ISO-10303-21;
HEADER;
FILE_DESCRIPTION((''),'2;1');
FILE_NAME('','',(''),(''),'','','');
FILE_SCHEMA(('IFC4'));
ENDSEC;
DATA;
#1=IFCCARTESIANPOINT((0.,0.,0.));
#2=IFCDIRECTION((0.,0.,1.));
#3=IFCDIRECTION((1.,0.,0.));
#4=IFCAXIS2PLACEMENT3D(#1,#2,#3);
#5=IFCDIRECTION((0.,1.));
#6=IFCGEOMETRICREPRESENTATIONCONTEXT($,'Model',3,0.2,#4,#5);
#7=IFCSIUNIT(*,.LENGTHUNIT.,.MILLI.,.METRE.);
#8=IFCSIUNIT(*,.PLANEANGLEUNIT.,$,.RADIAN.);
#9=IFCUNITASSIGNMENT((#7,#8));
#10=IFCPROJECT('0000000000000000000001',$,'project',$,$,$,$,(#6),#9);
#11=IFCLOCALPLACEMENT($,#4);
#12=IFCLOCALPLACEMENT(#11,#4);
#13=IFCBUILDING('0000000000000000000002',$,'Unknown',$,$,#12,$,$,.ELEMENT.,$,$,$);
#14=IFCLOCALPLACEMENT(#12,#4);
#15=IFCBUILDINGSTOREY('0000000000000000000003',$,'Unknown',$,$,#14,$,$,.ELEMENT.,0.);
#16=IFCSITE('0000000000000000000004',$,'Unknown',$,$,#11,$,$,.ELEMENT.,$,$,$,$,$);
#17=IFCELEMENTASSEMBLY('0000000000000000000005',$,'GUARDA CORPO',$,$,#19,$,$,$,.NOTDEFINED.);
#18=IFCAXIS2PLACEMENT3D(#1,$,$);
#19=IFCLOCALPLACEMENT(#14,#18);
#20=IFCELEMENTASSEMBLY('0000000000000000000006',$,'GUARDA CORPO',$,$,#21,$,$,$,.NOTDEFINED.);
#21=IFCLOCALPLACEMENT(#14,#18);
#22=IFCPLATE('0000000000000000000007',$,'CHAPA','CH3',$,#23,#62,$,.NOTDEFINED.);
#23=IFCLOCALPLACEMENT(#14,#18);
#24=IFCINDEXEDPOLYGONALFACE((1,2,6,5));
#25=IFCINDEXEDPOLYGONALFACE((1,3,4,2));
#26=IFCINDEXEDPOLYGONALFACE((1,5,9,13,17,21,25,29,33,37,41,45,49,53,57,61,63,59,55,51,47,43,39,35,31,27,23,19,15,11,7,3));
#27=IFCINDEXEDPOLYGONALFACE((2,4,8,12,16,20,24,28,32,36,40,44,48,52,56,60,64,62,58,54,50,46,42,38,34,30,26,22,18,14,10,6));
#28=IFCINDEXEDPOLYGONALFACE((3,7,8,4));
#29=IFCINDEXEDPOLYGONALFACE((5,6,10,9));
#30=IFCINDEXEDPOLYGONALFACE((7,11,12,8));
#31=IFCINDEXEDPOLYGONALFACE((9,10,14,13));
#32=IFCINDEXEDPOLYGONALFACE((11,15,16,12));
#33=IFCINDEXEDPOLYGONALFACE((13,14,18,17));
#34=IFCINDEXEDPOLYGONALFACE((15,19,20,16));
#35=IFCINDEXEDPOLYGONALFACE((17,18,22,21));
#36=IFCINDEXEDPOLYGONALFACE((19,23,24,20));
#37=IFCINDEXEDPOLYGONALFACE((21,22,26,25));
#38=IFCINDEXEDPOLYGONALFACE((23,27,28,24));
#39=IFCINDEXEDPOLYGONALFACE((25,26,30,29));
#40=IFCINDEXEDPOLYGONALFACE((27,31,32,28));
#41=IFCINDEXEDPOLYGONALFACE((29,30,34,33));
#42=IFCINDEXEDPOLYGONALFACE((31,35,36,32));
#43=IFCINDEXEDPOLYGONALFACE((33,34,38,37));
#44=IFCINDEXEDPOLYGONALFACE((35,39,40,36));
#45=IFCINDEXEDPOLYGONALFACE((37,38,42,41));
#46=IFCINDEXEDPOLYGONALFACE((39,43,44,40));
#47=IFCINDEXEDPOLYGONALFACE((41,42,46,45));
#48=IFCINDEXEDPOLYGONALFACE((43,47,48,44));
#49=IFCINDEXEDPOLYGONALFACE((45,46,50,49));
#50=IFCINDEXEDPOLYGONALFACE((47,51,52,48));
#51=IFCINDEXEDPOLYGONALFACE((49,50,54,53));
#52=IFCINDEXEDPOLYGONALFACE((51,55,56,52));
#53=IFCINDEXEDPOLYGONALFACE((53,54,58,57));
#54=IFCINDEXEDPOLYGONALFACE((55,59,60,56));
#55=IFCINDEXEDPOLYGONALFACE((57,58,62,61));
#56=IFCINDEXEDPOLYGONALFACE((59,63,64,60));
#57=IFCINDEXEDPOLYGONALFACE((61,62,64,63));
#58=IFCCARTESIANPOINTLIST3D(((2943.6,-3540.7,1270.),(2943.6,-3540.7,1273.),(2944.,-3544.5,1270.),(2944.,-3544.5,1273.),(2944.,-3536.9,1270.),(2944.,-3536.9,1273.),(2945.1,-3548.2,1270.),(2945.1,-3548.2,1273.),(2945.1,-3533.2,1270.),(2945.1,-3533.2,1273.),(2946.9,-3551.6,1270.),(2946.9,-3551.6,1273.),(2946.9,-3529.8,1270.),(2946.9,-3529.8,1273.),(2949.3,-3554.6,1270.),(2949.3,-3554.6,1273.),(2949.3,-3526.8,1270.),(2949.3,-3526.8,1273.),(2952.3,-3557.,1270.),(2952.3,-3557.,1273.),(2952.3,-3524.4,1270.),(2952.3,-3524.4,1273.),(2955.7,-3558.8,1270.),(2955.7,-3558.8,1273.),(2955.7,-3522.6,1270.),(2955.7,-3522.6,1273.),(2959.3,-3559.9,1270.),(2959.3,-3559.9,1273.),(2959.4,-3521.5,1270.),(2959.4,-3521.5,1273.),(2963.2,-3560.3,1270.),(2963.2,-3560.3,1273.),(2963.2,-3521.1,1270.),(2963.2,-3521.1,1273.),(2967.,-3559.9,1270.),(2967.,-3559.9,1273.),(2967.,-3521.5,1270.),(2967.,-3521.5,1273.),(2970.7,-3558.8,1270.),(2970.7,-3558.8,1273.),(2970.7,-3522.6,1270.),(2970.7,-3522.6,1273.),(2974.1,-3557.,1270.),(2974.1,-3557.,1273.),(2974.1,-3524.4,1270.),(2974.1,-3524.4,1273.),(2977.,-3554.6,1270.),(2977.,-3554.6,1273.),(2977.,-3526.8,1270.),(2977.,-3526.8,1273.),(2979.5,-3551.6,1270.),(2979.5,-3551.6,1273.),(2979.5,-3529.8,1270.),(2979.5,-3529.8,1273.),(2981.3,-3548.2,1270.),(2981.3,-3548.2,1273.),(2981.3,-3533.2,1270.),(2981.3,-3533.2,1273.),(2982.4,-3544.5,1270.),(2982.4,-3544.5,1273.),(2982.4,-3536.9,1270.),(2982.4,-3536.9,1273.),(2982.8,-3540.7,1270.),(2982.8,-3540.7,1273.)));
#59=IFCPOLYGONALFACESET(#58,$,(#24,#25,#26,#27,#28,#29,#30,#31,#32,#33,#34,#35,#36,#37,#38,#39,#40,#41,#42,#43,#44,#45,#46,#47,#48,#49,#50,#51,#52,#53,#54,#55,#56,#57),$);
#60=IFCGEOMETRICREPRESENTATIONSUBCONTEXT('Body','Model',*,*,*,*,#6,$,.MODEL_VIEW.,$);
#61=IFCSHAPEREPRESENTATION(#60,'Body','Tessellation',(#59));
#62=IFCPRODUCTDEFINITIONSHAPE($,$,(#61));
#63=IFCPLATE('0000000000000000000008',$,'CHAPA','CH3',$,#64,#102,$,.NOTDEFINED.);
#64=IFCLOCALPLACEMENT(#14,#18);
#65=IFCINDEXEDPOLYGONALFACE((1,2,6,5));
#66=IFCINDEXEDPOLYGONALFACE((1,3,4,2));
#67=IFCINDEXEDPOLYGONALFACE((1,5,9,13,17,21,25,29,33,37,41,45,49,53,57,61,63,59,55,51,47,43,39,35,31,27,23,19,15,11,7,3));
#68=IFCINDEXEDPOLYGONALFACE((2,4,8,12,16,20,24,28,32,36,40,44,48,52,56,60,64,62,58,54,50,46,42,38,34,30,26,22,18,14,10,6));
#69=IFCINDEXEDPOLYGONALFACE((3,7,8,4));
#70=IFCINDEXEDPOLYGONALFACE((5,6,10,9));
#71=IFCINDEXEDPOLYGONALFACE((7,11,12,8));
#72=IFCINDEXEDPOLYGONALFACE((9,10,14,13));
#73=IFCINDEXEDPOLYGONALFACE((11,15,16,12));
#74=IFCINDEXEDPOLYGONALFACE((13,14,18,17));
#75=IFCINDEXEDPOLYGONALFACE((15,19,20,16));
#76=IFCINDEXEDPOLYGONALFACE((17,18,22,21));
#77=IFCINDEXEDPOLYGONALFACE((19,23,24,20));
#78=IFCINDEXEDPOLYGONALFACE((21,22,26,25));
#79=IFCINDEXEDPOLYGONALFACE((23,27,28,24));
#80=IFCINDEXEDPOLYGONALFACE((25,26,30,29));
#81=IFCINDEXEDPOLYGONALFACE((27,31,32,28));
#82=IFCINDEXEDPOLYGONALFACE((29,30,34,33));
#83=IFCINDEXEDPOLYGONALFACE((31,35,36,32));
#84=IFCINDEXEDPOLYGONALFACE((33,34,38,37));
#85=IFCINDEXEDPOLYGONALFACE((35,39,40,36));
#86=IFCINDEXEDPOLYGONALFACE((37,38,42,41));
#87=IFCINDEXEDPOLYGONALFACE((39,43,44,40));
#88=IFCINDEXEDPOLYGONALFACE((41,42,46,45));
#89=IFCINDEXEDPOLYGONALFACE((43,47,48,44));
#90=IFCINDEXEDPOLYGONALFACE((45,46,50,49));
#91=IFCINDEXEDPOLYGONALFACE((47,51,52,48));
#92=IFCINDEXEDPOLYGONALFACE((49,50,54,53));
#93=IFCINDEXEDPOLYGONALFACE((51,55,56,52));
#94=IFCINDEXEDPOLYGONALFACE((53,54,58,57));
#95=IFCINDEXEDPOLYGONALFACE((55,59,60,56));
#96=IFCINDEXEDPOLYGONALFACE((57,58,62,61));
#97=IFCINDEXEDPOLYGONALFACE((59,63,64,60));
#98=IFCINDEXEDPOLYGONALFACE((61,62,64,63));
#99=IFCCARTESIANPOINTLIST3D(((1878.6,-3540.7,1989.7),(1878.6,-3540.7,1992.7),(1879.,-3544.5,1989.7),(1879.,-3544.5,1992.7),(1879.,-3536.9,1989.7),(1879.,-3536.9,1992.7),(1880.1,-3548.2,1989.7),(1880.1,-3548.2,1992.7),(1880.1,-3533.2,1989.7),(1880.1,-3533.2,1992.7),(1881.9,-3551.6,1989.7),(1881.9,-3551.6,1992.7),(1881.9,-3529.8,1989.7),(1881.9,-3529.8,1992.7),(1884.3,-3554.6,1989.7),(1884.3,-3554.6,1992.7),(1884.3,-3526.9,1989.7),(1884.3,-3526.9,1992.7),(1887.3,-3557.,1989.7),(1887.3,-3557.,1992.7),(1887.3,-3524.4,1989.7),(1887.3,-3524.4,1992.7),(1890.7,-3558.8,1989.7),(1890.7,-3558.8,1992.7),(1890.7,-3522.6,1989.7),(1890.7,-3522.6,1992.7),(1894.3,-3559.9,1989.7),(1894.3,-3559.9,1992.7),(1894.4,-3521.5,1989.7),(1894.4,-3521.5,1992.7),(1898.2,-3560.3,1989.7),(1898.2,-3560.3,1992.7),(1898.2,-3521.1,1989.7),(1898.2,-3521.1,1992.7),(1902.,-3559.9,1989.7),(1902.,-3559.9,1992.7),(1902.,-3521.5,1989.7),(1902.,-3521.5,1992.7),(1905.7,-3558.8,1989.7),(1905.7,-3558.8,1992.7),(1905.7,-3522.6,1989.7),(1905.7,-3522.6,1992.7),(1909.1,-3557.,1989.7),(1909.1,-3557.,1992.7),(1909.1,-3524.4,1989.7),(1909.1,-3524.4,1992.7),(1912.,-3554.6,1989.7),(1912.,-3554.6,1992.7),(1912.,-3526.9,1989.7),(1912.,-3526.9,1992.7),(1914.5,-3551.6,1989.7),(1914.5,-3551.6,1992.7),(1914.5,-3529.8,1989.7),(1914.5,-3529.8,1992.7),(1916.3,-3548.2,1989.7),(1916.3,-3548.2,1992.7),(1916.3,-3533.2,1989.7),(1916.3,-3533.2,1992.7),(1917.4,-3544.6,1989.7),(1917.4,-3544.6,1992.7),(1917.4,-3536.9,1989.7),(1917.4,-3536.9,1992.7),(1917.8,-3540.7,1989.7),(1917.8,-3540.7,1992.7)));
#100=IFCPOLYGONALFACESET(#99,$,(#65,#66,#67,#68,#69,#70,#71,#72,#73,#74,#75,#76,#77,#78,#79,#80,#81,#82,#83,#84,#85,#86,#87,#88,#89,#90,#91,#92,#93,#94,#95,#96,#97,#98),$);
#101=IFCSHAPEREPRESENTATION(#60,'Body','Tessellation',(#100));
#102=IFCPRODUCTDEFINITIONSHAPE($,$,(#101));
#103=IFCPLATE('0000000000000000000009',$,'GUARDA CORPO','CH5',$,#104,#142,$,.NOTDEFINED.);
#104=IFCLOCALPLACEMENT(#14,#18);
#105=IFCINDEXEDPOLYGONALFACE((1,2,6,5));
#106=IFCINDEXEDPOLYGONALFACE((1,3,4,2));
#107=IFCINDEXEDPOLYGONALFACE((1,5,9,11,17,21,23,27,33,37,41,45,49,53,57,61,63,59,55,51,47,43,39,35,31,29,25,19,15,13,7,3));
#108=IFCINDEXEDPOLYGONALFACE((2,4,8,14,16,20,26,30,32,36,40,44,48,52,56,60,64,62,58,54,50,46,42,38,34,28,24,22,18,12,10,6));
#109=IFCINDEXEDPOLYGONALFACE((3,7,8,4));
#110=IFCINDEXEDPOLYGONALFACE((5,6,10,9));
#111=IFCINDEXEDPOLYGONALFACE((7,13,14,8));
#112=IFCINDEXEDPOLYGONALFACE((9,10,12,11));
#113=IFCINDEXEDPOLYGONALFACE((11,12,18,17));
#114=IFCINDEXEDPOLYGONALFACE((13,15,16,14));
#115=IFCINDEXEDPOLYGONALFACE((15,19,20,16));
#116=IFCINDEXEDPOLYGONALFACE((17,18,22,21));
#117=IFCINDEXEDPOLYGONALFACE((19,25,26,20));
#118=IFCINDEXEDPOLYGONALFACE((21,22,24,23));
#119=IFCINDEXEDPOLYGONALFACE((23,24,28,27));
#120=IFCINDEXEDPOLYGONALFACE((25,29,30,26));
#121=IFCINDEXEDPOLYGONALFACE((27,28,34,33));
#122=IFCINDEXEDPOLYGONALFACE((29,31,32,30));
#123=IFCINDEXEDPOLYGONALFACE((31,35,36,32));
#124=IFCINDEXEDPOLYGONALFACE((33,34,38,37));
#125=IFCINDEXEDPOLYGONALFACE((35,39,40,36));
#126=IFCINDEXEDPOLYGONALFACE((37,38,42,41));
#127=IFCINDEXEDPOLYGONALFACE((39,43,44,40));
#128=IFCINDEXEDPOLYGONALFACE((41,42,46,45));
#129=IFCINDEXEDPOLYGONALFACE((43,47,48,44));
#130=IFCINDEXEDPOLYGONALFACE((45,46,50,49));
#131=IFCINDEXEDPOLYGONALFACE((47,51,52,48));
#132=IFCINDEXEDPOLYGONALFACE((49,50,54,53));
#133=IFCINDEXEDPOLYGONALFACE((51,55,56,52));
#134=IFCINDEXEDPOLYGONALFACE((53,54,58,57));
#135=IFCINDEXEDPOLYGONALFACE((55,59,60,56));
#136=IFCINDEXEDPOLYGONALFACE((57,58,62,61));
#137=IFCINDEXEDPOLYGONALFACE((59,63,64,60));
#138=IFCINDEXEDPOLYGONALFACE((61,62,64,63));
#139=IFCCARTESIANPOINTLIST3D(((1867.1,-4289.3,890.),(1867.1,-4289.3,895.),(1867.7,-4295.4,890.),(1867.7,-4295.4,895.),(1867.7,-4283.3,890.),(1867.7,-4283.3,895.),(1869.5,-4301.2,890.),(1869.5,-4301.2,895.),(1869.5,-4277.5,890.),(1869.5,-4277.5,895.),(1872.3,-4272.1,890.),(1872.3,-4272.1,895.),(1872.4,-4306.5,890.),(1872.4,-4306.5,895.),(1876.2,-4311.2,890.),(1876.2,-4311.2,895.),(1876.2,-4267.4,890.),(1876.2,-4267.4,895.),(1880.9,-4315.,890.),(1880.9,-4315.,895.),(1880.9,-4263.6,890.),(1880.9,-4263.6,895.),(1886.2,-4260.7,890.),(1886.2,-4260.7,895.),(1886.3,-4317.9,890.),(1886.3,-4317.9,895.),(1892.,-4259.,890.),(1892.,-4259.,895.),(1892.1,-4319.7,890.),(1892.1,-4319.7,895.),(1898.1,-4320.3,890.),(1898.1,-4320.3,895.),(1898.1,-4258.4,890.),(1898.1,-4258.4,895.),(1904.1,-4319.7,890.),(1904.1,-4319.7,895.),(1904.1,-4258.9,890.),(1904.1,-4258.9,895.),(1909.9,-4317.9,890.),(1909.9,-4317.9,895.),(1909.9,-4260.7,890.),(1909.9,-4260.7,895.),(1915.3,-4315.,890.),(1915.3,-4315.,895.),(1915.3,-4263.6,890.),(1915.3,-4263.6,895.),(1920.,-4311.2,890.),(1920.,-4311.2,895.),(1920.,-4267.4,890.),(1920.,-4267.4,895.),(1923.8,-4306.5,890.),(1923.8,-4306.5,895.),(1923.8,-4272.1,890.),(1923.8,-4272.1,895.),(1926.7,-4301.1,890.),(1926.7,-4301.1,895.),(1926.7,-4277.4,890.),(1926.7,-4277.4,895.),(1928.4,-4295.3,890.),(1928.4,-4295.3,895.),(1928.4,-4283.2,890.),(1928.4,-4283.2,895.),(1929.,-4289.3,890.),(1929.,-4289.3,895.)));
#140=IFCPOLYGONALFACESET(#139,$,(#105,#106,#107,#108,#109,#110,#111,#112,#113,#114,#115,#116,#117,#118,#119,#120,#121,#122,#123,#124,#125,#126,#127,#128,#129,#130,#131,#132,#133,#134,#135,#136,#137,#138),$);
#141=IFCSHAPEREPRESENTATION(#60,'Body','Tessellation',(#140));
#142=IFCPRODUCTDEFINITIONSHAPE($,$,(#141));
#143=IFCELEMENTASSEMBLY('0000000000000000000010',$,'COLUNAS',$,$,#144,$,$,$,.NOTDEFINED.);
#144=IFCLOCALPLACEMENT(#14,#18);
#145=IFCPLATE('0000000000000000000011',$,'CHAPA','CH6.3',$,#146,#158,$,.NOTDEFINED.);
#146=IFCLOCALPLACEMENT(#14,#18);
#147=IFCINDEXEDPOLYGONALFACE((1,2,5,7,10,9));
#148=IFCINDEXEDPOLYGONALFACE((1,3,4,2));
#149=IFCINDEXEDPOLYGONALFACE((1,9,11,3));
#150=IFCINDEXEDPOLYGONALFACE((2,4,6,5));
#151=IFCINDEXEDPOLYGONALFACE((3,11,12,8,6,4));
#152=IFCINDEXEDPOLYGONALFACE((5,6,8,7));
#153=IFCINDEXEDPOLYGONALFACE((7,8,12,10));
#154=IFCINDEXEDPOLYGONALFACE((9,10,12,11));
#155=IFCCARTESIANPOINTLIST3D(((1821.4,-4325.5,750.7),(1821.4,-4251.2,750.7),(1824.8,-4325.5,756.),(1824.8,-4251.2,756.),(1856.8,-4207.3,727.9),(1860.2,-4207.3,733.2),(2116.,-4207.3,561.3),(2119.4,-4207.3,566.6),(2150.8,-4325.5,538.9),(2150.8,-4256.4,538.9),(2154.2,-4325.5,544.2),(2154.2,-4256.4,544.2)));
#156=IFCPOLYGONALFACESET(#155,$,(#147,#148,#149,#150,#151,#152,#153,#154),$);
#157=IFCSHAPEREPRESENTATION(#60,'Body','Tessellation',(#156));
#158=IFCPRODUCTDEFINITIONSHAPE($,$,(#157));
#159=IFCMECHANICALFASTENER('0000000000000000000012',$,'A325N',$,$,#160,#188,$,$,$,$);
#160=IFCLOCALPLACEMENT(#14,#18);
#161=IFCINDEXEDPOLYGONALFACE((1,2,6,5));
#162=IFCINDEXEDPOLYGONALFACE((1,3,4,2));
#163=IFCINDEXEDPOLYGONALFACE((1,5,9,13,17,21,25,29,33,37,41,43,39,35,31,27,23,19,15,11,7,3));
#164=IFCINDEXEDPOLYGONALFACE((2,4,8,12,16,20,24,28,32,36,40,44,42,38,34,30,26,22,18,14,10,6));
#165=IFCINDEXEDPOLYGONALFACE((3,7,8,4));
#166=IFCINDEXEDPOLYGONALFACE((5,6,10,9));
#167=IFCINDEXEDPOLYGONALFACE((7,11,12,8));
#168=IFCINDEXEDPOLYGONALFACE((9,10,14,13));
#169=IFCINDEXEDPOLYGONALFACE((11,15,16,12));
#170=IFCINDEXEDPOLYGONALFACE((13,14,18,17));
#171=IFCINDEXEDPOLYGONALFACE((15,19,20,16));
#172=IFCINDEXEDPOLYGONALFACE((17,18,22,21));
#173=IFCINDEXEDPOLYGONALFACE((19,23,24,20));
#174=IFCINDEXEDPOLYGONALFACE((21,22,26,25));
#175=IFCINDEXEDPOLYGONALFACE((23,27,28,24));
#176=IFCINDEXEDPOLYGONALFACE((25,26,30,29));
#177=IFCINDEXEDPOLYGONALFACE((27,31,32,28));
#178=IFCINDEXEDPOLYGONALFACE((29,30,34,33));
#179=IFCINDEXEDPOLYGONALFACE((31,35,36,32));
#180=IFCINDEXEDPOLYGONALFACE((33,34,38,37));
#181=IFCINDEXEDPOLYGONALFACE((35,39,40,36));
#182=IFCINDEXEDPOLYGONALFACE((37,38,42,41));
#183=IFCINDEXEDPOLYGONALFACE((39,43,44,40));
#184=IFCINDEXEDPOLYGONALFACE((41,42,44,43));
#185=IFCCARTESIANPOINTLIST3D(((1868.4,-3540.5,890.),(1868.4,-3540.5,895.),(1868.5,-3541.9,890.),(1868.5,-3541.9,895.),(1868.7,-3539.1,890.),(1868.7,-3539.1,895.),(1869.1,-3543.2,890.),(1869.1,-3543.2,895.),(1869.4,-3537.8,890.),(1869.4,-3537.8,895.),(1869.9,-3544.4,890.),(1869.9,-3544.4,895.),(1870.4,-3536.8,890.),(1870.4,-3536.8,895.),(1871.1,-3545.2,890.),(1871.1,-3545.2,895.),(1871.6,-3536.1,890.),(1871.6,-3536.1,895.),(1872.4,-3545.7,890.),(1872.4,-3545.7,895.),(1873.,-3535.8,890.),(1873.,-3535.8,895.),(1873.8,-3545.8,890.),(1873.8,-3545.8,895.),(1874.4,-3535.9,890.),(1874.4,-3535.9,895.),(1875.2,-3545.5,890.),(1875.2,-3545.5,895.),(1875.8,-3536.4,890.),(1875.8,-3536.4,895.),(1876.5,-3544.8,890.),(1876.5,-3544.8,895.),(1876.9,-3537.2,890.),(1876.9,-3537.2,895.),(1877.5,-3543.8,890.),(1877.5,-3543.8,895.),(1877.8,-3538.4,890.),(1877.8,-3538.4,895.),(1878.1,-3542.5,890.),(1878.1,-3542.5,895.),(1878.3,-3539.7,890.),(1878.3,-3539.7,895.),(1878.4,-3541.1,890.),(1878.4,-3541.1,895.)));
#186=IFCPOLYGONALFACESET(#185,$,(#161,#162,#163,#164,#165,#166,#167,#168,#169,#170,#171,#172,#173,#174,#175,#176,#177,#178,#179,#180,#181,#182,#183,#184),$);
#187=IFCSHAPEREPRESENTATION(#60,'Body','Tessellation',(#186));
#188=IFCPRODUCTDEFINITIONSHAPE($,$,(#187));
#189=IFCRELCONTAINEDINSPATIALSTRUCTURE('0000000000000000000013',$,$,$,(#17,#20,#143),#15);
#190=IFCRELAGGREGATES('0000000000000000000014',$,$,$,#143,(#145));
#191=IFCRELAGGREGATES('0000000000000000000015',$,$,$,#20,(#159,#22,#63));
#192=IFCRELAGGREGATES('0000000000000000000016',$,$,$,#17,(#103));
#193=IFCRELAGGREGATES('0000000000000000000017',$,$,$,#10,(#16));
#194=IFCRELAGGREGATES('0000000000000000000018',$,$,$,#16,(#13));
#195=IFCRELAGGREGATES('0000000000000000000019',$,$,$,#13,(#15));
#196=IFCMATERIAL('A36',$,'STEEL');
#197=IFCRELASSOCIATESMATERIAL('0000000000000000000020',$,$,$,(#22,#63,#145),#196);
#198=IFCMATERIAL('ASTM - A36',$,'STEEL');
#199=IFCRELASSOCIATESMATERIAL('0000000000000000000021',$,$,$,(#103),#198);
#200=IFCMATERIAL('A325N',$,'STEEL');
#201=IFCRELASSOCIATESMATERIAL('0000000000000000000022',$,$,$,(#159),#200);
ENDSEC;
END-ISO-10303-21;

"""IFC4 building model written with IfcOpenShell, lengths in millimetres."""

from ifc_helpers import new_model, si_unit, direction, frame, origin_with_axes, place, context, subcontext, project, spatial, line, arc, indexed_curve, outline, extrude, source, transform, mapped, material, element, aggregate, save


model = new_model("IFC4")

# Units and contexts
model_context = context("Model", 3, precision=0.2, world=origin_with_axes(), true_north=direction((0.0, 1.0)))
body_context = subcontext(model_context, "Body", "Model", "MODEL_VIEW")
ifc_project = project(units=[si_unit("LENGTHUNIT", "METRE", prefix="MILLI"), si_unit("PLANEANGLEUNIT", "RADIAN")], contexts=[model_context])

# Site, building, storey
site_placement = place(None, origin_with_axes())
site = spatial("IfcSite", under=ifc_project, at=site_placement, Name="Unknown", CompositionType="ELEMENT")
building_placement = place(site_placement, origin_with_axes())
building = spatial("IfcBuilding", under=site, at=building_placement, Name="Unknown", CompositionType="ELEMENT")
storey_placement = place(building_placement, origin_with_axes())
storey = spatial("IfcBuildingStorey", under=building, at=storey_placement, Name="Unknown", CompositionType="ELEMENT", Elevation=0.0)

# Element assembly
assembly_1_placement = place(storey_placement, frame((833.2, -4289.3, 1615.0), z_axis=(-0.000512, 1.0, -0.000003), x_axis=(0.000003, 0.000003, 1.0)))
assembly_1 = element("IfcElementAssembly", 1, at=assembly_1_placement, inside=storey, Name="GUARDA CORPO", PredefinedType="NOTDEFINED")

# Shared definitions
ifc_material_1 = material(Name="A36", Category="STEEL")

# Element assembly
assembly_2_placement = place(storey_placement, frame((833.2, -3540.7, 1615.0), z_axis=(-0.000512, -1.0, -0.000003), x_axis=(0.000003, -0.000003, 1.0)))
assembly_2 = element("IfcElementAssembly", 2, at=assembly_2_placement, inside=storey, Name="GUARDA CORPO", PredefinedType="NOTDEFINED")

# Plates
ifc_material_2 = material(Name="ASTM - A36", Category="STEEL")
plate_1_placement = place(assembly_2_placement, frame((-343.5, -2110.8, 2.7), z_axis=(1.0, 0.0, 0.0), x_axis=(0.0, -0.290285, 0.95694)))
plate_1 = element("IfcPlate", 3, at=plate_1_placement, material=ifc_material_1, Name="CHAPA", Description="CH3", PredefinedType="NOTDEFINED", context=body_context, shape_type="SolidModel", body=[
    extrude(outline(indexed_curve([(0.0, 0.0), (3.8, 0.0), (7.6, 0.7), (11.2, 2.2), (14.4, 4.4), (17.1, 7.1), (19.2, 10.3), (20.7, 13.8), (21.4, 17.6), (21.4, 21.4), (20.7, 25.2), (19.2, 28.7), (17.1, 31.9), (14.4, 34.7), (11.2, 36.8), (7.6, 38.3), (3.8, 39.0), (0.0, 39.0), (-3.8, 38.3), (-7.3, 36.8), (-10.5, 34.7), (-13.2, 31.9), (-15.4, 28.7), (-16.8, 25.2), (-17.6, 21.4), (-17.6, 17.6), (-16.8, 13.8), (-15.4, 10.3), (-13.2, 7.1), (-10.5, 4.4), (-7.3, 2.2), (-3.8, 0.7)], segments=[line(1, 2, 3, 4, 5, 6, 7, 8, 9, 10, 11, 12, 13, 14, 15, 16, 17, 18, 19, 20, 21, 22, 23, 24, 25, 26, 27, 28, 29, 30, 31, 32, 1)])), frame((0.0, 0.0, 1.5), z_axis=(0.0, 0.0, 1.0), x_axis=(1.0, 0.0, 0.0)), (0.0, 0.0, -1.0), 3.0),
])
plate_2_placement = place(assembly_2_placement, frame((376.2, -1045.8, 3.3), z_axis=(1.0, 0.0, 0.0), x_axis=(0.0, -0.290285, 0.95694)))
plate_2 = element("IfcPlate", 4, at=plate_2_placement, material=ifc_material_1, Name="CHAPA", Description="CH3", PredefinedType="NOTDEFINED", context=body_context, shape_type="SolidModel", body=[
    extrude(outline(indexed_curve([(0.0, 0.0), (3.8, 0.0), (7.6, 0.7), (11.2, 2.2), (14.4, 4.4), (17.1, 7.1), (19.2, 10.3), (20.7, 13.8), (21.4, 17.6), (21.4, 21.4), (20.7, 25.2), (19.2, 28.7), (17.1, 31.9), (14.4, 34.7), (11.2, 36.8), (7.6, 38.3), (3.8, 39.0), (0.0, 39.0), (-3.8, 38.3), (-7.3, 36.8), (-10.5, 34.7), (-13.2, 31.9), (-15.4, 28.7), (-16.8, 25.2), (-17.6, 21.4), (-17.6, 17.6), (-16.8, 13.8), (-15.4, 10.3), (-13.2, 7.1), (-10.5, 4.4), (-7.3, 2.2), (-3.8, 0.7)], segments=[line(1, 2, 3, 4, 5, 6, 7, 8, 9, 10, 11, 12, 13, 14, 15, 16, 17, 18, 19, 20, 21, 22, 23, 24, 25, 26, 27, 28, 29, 30, 31, 32, 1)])), frame((0.0, 0.0, 1.5), z_axis=(0.0, 0.0, 1.0), x_axis=(1.0, 0.0, 0.0)), (0.0, 0.0, -1.0), 3.0),
])
plate_3_placement = place(assembly_1_placement, frame((-722.5, 1095.3, 5.5), z_axis=(1.0, 0.0, 0.0), x_axis=(0.0, -0.290285, 0.95694)))
plate_3 = element("IfcPlate", 5, at=plate_3_placement, material=ifc_material_2, Name="GUARDA CORPO", Description="CH5", PredefinedType="NOTDEFINED", context=body_context, shape_type="SolidModel", body=[
    extrude(outline(indexed_curve([(0.0, 0.0), (6.1, 0.0), (12.0, 1.2), (17.6, 3.5), (22.7, 6.9), (27.0, 11.2), (30.3, 16.2), (32.7, 21.8), (33.8, 27.8), (33.8, 33.8), (32.7, 39.8), (30.3, 45.4), (27.0, 50.4), (22.7, 54.7), (17.6, 58.1), (12.0, 60.4), (6.1, 61.6), (0.0, 61.6), (-6.0, 60.4), (-11.6, 58.1), (-16.6, 54.7), (-20.9, 50.4), (-24.3, 45.4), (-26.6, 39.8), (-27.8, 33.8), (-27.8, 27.8), (-26.6, 21.8), (-24.3, 16.2), (-20.9, 11.2), (-16.6, 6.9), (-11.6, 3.5), (-6.0, 1.2)], segments=[line(1, 2, 3, 4, 5, 6, 7, 8, 9, 10, 11, 12, 13, 14, 15, 16, 17, 18, 19, 20, 21, 22, 23, 24, 25, 26, 27, 28, 29, 30, 31, 32, 1)])), frame((0.0, 0.0, 2.5), z_axis=(0.0, 0.0, 1.0), x_axis=(1.0, 0.0, 0.0)), (0.0, 0.0, -1.0), 5.0),
])

# Element assembly, plate
assembly_3_placement = place(storey_placement, frame((2988.4, -4354.0, 7.9), z_axis=(0.0, -1.0, 0.0), x_axis=(0.0, 0.0, 1.0)))
assembly_3 = element("IfcElementAssembly", 6, at=assembly_3_placement, inside=storey, Name="COLUNAS", PredefinedType="NOTDEFINED")
plate_4_placement = place(assembly_3_placement, frame((745.4, 1165.4, -28.5), z_axis=(0.841179, -0.540757, 0.0), x_axis=(-0.540757, -0.841179, 0.0)))
plate_4 = element("IfcPlate", 7, at=plate_4_placement, material=ifc_material_1, Name="CHAPA", Description="CH6.3", PredefinedType="NOTDEFINED", context=body_context, shape_type="SolidModel", body=[
    extrude(outline(indexed_curve([(0.0, 0.0), (391.6, 0.0), (391.6, 69.1), (350.2, 118.2), (42.1, 118.2), (0.0, 74.3)], segments=[line(1, 2, 3, 4, 5, 6, 1)])), frame((0.0, 0.0, 3.1), z_axis=(0.0, 0.0, 1.0), x_axis=(1.0, 0.0, 0.0)), (0.0, 0.0, -1.0), 6.3),
])
aggregate(assembly_3, [plate_4])

# Shared definitions
ifc_material_3 = material(Name="A325N", Category="STEEL")

# Mechanical fastener
shared_shape_1 = source(origin_with_axes(), body_context, "Body", "SweptSolid", [
    extrude(outline(indexed_curve([(5.0, 0.0), (0.0, 5.0), (-5.0, 0.0), (0.0, -5.0)], segments=[arc(1, 2, 3), arc(3, 4, 1)])), frame((0.0, 0.0, 0.0), z_axis=(0.0, 0.0, -1.0), x_axis=(0.0, 1.0, 0.0)), (0.0, 0.0, 1.0), 5.0),
])
mechanical_fastener_1_placement = place(assembly_2_placement, frame((-720.0, -1040.2, -0.5), z_axis=(1.0, 0.000005, -0.000003), x_axis=(0.000005, -0.882404, 0.470493)))
mechanical_fastener_1 = element("IfcMechanicalFastener", 8, at=mechanical_fastener_1_placement, material=ifc_material_3, Name="A325N", context=body_context, shape_type="MappedRepresentation", body=[
    mapped(shared_shape_1, transform((0.0, 0.0, 0.0))),
])
aggregate(assembly_2, [mechanical_fastener_1, plate_1, plate_2])
aggregate(assembly_1, [plate_3])

save(model, "model.ifc")
